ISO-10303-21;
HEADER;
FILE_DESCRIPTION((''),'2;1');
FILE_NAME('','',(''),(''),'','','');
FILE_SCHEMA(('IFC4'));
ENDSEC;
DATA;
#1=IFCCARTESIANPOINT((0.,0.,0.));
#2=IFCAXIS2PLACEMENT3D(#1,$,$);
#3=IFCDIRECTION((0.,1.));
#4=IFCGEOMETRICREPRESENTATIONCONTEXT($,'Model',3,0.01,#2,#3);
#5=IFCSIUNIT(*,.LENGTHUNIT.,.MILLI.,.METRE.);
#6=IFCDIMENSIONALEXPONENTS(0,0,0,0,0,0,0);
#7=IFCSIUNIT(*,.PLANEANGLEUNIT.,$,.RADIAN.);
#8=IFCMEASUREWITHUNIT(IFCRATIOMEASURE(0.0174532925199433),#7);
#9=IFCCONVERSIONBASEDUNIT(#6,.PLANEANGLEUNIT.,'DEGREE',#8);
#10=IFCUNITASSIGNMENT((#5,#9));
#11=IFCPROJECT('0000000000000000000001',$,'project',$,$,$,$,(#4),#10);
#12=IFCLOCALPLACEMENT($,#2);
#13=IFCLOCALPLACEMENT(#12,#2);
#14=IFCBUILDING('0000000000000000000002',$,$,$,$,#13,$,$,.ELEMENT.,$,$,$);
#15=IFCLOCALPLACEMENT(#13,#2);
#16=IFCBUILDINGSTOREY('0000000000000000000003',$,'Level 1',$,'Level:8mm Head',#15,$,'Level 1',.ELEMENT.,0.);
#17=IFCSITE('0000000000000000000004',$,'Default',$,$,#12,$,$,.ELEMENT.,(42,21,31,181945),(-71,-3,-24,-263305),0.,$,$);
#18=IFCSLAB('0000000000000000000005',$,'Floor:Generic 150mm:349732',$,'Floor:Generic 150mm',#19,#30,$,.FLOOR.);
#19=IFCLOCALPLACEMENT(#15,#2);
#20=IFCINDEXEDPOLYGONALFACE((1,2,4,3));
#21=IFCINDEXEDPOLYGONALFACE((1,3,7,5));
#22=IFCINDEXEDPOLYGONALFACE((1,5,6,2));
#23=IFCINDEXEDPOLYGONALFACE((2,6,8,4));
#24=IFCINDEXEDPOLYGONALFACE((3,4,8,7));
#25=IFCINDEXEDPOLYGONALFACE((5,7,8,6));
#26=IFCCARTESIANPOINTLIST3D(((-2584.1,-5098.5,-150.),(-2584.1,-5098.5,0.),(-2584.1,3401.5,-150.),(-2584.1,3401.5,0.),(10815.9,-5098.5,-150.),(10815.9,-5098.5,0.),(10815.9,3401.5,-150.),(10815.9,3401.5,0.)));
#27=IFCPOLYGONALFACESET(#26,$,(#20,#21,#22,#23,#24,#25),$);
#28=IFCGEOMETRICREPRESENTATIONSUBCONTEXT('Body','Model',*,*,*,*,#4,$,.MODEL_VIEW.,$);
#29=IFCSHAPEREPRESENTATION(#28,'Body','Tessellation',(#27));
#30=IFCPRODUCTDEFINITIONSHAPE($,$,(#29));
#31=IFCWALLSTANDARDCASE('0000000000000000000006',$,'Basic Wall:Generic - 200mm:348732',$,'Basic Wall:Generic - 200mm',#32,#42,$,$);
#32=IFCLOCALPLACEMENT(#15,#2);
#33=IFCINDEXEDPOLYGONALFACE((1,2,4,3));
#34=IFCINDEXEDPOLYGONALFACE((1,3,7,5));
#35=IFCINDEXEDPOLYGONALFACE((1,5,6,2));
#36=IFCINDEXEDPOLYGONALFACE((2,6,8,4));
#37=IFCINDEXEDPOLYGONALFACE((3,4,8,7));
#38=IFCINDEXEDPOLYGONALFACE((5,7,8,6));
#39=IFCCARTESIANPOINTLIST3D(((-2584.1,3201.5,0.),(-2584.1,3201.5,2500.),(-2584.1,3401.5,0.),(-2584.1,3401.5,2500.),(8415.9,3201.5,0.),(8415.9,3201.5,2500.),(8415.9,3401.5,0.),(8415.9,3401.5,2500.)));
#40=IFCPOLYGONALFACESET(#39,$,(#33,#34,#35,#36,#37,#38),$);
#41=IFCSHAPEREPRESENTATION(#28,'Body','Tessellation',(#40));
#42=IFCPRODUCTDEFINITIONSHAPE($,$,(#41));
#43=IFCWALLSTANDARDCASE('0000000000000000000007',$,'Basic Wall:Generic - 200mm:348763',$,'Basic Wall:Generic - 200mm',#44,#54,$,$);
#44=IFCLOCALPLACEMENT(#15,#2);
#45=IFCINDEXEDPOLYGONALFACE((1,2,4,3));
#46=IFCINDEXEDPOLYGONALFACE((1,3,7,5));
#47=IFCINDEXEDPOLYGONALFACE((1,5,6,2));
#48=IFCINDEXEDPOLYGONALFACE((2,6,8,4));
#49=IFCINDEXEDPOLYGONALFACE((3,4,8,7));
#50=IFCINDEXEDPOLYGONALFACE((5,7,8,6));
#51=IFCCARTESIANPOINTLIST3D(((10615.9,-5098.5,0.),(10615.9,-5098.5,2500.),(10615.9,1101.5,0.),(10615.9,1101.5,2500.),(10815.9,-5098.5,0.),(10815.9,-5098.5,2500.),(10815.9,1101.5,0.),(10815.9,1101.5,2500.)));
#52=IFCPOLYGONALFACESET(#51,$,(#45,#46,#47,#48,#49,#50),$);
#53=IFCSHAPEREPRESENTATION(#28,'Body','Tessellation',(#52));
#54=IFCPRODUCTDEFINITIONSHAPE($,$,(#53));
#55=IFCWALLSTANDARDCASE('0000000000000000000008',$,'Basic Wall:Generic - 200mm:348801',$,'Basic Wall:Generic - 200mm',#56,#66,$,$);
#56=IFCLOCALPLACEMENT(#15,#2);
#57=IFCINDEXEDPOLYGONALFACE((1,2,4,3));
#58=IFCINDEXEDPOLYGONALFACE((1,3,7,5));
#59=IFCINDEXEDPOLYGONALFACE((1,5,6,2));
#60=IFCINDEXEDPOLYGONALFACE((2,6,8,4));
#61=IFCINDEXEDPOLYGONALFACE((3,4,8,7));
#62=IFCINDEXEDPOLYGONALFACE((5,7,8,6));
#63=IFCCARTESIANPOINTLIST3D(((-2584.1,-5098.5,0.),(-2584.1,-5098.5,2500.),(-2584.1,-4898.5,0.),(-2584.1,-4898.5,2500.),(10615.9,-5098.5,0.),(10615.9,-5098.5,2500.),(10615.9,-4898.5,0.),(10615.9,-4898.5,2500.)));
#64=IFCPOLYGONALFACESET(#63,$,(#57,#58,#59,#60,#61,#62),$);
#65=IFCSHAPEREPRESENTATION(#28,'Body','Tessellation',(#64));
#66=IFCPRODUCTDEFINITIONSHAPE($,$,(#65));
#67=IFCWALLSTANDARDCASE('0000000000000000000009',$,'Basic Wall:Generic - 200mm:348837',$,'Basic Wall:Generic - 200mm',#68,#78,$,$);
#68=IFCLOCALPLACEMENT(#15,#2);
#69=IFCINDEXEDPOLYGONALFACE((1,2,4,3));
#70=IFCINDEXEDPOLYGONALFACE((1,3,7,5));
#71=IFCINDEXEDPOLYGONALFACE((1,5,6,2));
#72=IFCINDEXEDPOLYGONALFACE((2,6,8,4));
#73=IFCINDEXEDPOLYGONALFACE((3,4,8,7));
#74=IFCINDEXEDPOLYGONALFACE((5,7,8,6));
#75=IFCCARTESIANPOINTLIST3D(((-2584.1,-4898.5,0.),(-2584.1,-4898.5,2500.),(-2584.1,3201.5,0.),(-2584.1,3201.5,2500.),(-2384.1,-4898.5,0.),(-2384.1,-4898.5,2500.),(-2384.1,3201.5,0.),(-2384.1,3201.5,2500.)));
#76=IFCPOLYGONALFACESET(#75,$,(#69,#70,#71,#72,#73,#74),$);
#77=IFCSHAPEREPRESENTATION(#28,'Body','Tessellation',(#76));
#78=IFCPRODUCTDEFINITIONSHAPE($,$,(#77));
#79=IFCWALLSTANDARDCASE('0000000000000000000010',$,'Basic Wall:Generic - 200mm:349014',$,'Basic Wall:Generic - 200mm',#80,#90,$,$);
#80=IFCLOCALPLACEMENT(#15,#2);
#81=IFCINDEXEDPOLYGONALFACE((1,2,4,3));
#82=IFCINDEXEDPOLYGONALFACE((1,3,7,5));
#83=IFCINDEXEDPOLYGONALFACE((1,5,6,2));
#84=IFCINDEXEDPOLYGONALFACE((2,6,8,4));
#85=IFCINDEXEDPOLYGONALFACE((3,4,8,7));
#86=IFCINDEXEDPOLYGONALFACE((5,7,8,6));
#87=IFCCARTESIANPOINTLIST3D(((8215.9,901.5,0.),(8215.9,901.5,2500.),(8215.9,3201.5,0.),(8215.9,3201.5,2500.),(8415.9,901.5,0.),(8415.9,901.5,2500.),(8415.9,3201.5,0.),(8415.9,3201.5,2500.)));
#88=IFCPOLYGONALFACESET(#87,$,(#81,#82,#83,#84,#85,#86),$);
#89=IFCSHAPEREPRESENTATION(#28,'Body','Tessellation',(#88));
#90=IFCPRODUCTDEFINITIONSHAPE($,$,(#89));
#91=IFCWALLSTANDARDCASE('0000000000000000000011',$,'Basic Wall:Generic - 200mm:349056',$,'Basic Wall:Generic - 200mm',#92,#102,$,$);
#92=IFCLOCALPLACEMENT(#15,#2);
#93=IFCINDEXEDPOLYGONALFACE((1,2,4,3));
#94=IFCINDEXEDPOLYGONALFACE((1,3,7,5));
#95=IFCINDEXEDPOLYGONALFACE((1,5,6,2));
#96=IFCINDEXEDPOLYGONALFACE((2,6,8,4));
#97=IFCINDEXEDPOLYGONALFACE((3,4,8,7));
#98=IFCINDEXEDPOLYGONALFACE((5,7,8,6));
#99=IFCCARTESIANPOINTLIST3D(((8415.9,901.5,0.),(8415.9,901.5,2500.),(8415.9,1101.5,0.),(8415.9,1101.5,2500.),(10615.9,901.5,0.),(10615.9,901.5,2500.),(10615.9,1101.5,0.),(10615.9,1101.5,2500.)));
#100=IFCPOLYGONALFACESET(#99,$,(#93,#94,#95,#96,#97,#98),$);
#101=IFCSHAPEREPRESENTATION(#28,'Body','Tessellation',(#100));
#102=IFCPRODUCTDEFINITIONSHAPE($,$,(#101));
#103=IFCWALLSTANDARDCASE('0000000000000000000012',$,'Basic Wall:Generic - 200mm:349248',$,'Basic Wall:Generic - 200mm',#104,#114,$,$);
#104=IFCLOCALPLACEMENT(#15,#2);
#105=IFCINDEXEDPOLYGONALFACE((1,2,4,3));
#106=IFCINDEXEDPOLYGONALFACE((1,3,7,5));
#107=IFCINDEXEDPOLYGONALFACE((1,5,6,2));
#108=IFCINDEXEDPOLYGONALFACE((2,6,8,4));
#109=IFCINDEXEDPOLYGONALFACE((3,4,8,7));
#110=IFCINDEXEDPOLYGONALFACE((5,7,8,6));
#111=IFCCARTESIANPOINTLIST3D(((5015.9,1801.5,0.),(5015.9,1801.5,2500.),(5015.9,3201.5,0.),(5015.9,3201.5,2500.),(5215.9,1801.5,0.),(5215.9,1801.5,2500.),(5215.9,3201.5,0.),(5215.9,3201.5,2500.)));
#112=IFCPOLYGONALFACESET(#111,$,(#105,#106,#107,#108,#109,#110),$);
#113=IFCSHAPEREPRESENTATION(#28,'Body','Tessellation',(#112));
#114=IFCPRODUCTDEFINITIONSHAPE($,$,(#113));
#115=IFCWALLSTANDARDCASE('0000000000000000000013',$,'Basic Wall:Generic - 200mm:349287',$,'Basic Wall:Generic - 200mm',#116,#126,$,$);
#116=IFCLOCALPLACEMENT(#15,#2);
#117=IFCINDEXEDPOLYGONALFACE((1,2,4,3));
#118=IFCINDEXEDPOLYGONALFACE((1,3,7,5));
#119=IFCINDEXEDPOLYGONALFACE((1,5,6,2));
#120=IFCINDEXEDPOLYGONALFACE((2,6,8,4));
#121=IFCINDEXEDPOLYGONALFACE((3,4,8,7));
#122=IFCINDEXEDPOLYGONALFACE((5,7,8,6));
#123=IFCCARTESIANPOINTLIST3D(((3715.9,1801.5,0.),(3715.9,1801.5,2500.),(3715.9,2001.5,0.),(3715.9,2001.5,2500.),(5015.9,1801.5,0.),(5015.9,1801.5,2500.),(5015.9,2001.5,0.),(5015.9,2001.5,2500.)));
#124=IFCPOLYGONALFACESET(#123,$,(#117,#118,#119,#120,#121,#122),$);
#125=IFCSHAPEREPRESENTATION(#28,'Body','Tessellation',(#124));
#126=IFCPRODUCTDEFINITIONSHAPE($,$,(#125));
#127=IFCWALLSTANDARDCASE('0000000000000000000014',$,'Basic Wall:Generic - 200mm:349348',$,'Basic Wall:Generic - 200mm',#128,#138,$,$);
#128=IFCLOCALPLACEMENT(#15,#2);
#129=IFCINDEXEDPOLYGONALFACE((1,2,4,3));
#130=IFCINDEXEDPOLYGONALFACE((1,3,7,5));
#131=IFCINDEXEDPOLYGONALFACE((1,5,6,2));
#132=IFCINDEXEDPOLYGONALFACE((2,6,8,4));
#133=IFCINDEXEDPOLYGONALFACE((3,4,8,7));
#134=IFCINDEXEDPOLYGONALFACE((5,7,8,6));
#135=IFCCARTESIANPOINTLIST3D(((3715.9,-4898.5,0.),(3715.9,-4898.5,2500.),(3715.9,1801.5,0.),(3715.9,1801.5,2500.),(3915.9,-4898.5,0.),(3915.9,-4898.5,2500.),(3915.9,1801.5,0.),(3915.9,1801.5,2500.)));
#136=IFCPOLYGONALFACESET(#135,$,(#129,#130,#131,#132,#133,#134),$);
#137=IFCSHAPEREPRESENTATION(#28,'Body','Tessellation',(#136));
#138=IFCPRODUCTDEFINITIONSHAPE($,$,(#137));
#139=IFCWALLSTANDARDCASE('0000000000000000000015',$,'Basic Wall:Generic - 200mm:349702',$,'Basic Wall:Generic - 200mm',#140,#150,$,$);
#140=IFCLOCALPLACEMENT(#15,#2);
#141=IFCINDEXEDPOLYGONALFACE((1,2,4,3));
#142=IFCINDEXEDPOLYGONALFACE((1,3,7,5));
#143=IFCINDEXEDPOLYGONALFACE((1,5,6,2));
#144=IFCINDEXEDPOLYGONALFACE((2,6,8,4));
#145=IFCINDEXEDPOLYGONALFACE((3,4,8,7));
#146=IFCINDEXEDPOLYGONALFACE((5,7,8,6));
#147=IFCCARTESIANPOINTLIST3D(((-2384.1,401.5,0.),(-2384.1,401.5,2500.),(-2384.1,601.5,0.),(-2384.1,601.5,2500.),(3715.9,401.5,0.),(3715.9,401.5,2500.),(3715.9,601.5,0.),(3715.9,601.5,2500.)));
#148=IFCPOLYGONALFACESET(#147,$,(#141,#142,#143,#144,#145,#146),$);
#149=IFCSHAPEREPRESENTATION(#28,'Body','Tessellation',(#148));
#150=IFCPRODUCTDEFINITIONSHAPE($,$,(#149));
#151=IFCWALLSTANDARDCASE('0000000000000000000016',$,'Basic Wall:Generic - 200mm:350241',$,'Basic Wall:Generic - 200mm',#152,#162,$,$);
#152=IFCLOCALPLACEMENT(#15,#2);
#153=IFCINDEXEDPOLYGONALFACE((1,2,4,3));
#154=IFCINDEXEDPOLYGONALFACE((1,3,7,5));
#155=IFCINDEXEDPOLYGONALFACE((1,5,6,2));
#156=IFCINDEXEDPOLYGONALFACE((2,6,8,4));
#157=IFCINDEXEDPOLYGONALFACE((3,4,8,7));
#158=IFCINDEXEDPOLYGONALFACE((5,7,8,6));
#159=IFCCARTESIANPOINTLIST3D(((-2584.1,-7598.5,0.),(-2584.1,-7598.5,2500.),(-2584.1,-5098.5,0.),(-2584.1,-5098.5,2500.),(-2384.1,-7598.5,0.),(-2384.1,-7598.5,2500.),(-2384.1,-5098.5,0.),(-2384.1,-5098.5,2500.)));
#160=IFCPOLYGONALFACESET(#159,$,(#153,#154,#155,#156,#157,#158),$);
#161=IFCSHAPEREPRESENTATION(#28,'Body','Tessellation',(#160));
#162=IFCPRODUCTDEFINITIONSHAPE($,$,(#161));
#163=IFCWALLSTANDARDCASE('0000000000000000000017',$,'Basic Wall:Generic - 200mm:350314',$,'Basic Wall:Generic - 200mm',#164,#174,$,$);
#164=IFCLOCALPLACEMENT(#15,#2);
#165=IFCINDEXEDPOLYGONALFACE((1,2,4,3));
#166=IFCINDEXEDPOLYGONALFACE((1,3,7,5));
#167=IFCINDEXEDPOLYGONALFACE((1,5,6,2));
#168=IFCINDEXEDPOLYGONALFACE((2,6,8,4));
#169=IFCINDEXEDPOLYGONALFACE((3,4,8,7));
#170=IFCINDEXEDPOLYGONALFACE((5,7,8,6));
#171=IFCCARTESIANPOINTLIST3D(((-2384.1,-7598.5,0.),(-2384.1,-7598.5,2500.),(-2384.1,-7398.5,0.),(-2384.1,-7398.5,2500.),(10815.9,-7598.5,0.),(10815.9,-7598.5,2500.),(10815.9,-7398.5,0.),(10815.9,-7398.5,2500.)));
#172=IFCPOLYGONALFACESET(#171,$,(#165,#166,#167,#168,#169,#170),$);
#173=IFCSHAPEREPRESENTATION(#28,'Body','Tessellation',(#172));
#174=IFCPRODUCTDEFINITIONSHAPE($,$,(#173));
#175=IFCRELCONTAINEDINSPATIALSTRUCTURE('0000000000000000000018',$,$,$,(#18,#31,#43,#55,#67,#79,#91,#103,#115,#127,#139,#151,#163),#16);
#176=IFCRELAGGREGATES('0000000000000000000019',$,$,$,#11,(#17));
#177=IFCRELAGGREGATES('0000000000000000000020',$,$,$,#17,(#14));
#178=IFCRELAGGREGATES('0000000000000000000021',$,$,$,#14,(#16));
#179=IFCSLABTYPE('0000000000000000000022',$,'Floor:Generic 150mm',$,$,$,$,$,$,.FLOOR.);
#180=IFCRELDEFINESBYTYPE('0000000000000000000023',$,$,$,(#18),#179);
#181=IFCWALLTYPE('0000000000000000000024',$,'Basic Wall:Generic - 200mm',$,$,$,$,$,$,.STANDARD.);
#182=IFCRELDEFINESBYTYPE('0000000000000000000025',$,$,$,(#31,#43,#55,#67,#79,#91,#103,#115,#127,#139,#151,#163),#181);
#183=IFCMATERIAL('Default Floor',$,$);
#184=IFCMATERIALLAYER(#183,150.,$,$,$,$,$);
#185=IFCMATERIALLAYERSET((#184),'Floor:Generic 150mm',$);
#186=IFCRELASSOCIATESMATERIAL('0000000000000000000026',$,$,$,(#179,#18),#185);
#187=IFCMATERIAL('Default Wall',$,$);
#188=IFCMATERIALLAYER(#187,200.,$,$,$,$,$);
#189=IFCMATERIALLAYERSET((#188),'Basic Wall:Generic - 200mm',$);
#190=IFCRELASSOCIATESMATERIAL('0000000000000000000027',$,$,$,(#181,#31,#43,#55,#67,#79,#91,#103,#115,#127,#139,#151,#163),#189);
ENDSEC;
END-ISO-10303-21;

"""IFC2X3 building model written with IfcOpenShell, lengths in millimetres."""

from ifc_helpers import new_model, entity, si_unit, converted_unit, direction, frame, frame_2d, origin, place, context, subcontext, project, spatial, rectangle, extrude, material, layer, layer_set, layer_usage, type_object, element, save


model = new_model("IFC2X3")

# Units and contexts
model_context = context("Model", 3, precision=0.01, world=origin(), true_north=direction((0.0, 1.0)))
body_context = subcontext(model_context, "Body", "Model", "MODEL_VIEW")
ifc_project = project(units=[si_unit("LENGTHUNIT", "METRE", prefix="MILLI"), converted_unit("PLANEANGLEUNIT", "DEGREE", entity("IfcRatioMeasure", 0.0174532925199433), si_unit("PLANEANGLEUNIT", "RADIAN"), dimensions=[0, 0, 0, 0, 0, 0, 0])], contexts=[model_context])

# Site, building, storey
site_placement = place(None, origin())
site = spatial("IfcSite", under=ifc_project, at=site_placement, Name="Default", CompositionType="ELEMENT", RefLatitude=(42, 21, 31, 181945), RefLongitude=(-71, -3, -24, -263305), RefElevation=0.0)
building_placement = place(site_placement, origin())
building = spatial("IfcBuilding", under=site, at=building_placement, CompositionType="ELEMENT")
storey_placement = place(building_placement, origin())
storey = spatial("IfcBuildingStorey", under=building, at=storey_placement, Name="Level 1", ObjectType="Level:8mm Head", LongName="Level 1", CompositionType="ELEMENT", Elevation=0.0)

# Slab
ifc_material_1 = material(Name="Default Floor")
ifc_layer_1 = layer(ifc_material_1, 150.0)
ifc_layer_set_1 = layer_set([ifc_layer_1], Name="Floor:Generic 150mm")
ifc_layer_usage_1 = layer_usage(ifc_layer_set_1, "AXIS3", "POSITIVE", 0.0)
slab_type = type_object("IfcSlabType", Name="Floor:Generic 150mm", PredefinedType="FLOOR", material=ifc_layer_set_1)
slab_placement = place(storey_placement, origin())
element("IfcSlab", 1, at=slab_placement, inside=storey, type_object=slab_type, material=ifc_layer_usage_1, Name="Floor:Generic 150mm:349732", ObjectType="Floor:Generic 150mm", PredefinedType="FLOOR", context=body_context, shape_type="SweptSolid", body=[
    extrude(rectangle(XDim=8500.0, YDim=13400.0, at=frame_2d((0.0, 0.0), x_axis=(1.0, 0.0))), frame((4115.9, -848.5, 0.0), z_axis=(0.0, 0.0, -1.0), x_axis=(0.0, 1.0, 0.0)), (0.0, 0.0, 1.0), 150.0),
])

# Walls
ifc_material_2 = material(Name="Default Wall")
ifc_layer_2 = layer(ifc_material_2, 200.0)
ifc_layer_set_2 = layer_set([ifc_layer_2], Name="Basic Wall:Generic - 200mm")
ifc_layer_usage_2 = layer_usage(ifc_layer_set_2, "AXIS2", "NEGATIVE", 100.0)
wall_type = type_object("IfcWallType", Name="Basic Wall:Generic - 200mm", PredefinedType="STANDARD", material=ifc_layer_set_2)
wall_1_placement = place(storey_placement, frame((-2584.1, 3301.5, 0.0)))
element("IfcWallStandardCase", 2, at=wall_1_placement, inside=storey, type_object=wall_type, material=ifc_layer_usage_2, Name="Basic Wall:Generic - 200mm:348732", ObjectType="Basic Wall:Generic - 200mm", context=body_context, shape_type="SweptSolid", body=[
    extrude(rectangle(XDim=11000.0, YDim=200.0, at=frame_2d((5500.0, 0.0), x_axis=(-1.0, 0.0))), origin(), (0.0, 0.0, 1.0), 2500.0),
])
ifc_layer_usage_3 = layer_usage(ifc_layer_set_2, "AXIS2", "NEGATIVE", 100.0)
wall_2_placement = place(storey_placement, frame((10715.9, 1101.5, 0.0), z_axis=(0.0, 0.0, 1.0), x_axis=(0.0, -1.0, 0.0)))
element("IfcWallStandardCase", 3, at=wall_2_placement, inside=storey, type_object=wall_type, material=ifc_layer_usage_3, Name="Basic Wall:Generic - 200mm:348763", ObjectType="Basic Wall:Generic - 200mm", context=body_context, shape_type="SweptSolid", body=[
    extrude(rectangle(XDim=6200.0, YDim=200.0, at=frame_2d((3100.0, 0.0), x_axis=(-1.0, 0.0))), origin(), (0.0, 0.0, 1.0), 2500.0),
])
ifc_layer_usage_4 = layer_usage(ifc_layer_set_2, "AXIS2", "NEGATIVE", 100.0)
wall_3_placement = place(storey_placement, frame((10615.9, -4998.5, 0.0), z_axis=(0.0, 0.0, 1.0), x_axis=(-1.0, 0.0, 0.0)))
element("IfcWallStandardCase", 4, at=wall_3_placement, inside=storey, type_object=wall_type, material=ifc_layer_usage_4, Name="Basic Wall:Generic - 200mm:348801", ObjectType="Basic Wall:Generic - 200mm", context=body_context, shape_type="SweptSolid", body=[
    extrude(rectangle(XDim=13200.0, YDim=200.0, at=frame_2d((6600.0, 0.0), x_axis=(-1.0, 0.0))), origin(), (0.0, 0.0, 1.0), 2500.0),
])
ifc_layer_usage_5 = layer_usage(ifc_layer_set_2, "AXIS2", "NEGATIVE", 100.0)
wall_4_placement = place(storey_placement, frame((-2484.1, -4898.5, 0.0), z_axis=(0.0, 0.0, 1.0), x_axis=(0.0, 1.0, 0.0)))
element("IfcWallStandardCase", 5, at=wall_4_placement, inside=storey, type_object=wall_type, material=ifc_layer_usage_5, Name="Basic Wall:Generic - 200mm:348837", ObjectType="Basic Wall:Generic - 200mm", context=body_context, shape_type="SweptSolid", body=[
    extrude(rectangle(XDim=8100.0, YDim=200.0, at=frame_2d((4050.0, 0.0), x_axis=(-1.0, 0.0))), origin(), (0.0, 0.0, 1.0), 2500.0),
])
ifc_layer_usage_6 = layer_usage(ifc_layer_set_2, "AXIS2", "NEGATIVE", 100.0)
wall_5_placement = place(storey_placement, frame((8315.9, 3201.5, 0.0), z_axis=(0.0, 0.0, 1.0), x_axis=(0.0, -1.0, 0.0)))
element("IfcWallStandardCase", 6, at=wall_5_placement, inside=storey, type_object=wall_type, material=ifc_layer_usage_6, Name="Basic Wall:Generic - 200mm:349014", ObjectType="Basic Wall:Generic - 200mm", context=body_context, shape_type="SweptSolid", body=[
    extrude(rectangle(XDim=2300.0, YDim=200.0, at=frame_2d((1150.0, 0.0), x_axis=(-1.0, 0.0))), origin(), (0.0, 0.0, 1.0), 2500.0),
])
ifc_layer_usage_7 = layer_usage(ifc_layer_set_2, "AXIS2", "NEGATIVE", 100.0)
wall_6_placement = place(storey_placement, frame((8415.9, 1001.5, 0.0)))
element("IfcWallStandardCase", 7, at=wall_6_placement, inside=storey, type_object=wall_type, material=ifc_layer_usage_7, Name="Basic Wall:Generic - 200mm:349056", ObjectType="Basic Wall:Generic - 200mm", context=body_context, shape_type="SweptSolid", body=[
    extrude(rectangle(XDim=2200.0, YDim=200.0, at=frame_2d((1100.0, 0.0), x_axis=(-1.0, 0.0))), origin(), (0.0, 0.0, 1.0), 2500.0),
])
ifc_layer_usage_8 = layer_usage(ifc_layer_set_2, "AXIS2", "NEGATIVE", 100.0)
wall_7_placement = place(storey_placement, frame((5115.9, 3201.5, 0.0), z_axis=(0.0, 0.0, 1.0), x_axis=(0.0, -1.0, 0.0)))
element("IfcWallStandardCase", 8, at=wall_7_placement, inside=storey, type_object=wall_type, material=ifc_layer_usage_8, Name="Basic Wall:Generic - 200mm:349248", ObjectType="Basic Wall:Generic - 200mm", context=body_context, shape_type="SweptSolid", body=[
    extrude(rectangle(XDim=1400.0, YDim=200.0, at=frame_2d((700.0, 0.0), x_axis=(-1.0, 0.0))), origin(), (0.0, 0.0, 1.0), 2500.0),
])
ifc_layer_usage_9 = layer_usage(ifc_layer_set_2, "AXIS2", "NEGATIVE", 100.0)
wall_8_placement = place(storey_placement, frame((5015.9, 1901.5, 0.0), z_axis=(0.0, 0.0, 1.0), x_axis=(-1.0, 0.0, 0.0)))
element("IfcWallStandardCase", 9, at=wall_8_placement, inside=storey, type_object=wall_type, material=ifc_layer_usage_9, Name="Basic Wall:Generic - 200mm:349287", ObjectType="Basic Wall:Generic - 200mm", context=body_context, shape_type="SweptSolid", body=[
    extrude(rectangle(XDim=1300.0, YDim=200.0, at=frame_2d((650.0, 0.0), x_axis=(-1.0, 0.0))), origin(), (0.0, 0.0, 1.0), 2500.0),
])
ifc_layer_usage_10 = layer_usage(ifc_layer_set_2, "AXIS2", "NEGATIVE", 100.0)
wall_9_placement = place(storey_placement, frame((3815.9, 1801.5, 0.0), z_axis=(0.0, 0.0, 1.0), x_axis=(0.0, -1.0, 0.0)))
element("IfcWallStandardCase", 10, at=wall_9_placement, inside=storey, type_object=wall_type, material=ifc_layer_usage_10, Name="Basic Wall:Generic - 200mm:349348", ObjectType="Basic Wall:Generic - 200mm", context=body_context, shape_type="SweptSolid", body=[
    extrude(rectangle(XDim=6700.0, YDim=200.0, at=frame_2d((3350.0, 0.0), x_axis=(-1.0, 0.0))), origin(), (0.0, 0.0, 1.0), 2500.0),
])
ifc_layer_usage_11 = layer_usage(ifc_layer_set_2, "AXIS2", "NEGATIVE", 100.0)
wall_10_placement = place(storey_placement, frame((3715.9, 501.5, 0.0), z_axis=(0.0, 0.0, 1.0), x_axis=(-1.0, 0.0, 0.0)))
element("IfcWallStandardCase", 11, at=wall_10_placement, inside=storey, type_object=wall_type, material=ifc_layer_usage_11, Name="Basic Wall:Generic - 200mm:349702", ObjectType="Basic Wall:Generic - 200mm", context=body_context, shape_type="SweptSolid", body=[
    extrude(rectangle(XDim=6100.0, YDim=200.0, at=frame_2d((3050.0, 0.0), x_axis=(-1.0, 0.0))), origin(), (0.0, 0.0, 1.0), 2500.0),
])
ifc_layer_usage_12 = layer_usage(ifc_layer_set_2, "AXIS2", "NEGATIVE", 100.0)
wall_11_placement = place(storey_placement, frame((-2484.1, -5098.5, 0.0), z_axis=(0.0, 0.0, 1.0), x_axis=(0.0, -1.0, 0.0)))
element("IfcWallStandardCase", 12, at=wall_11_placement, inside=storey, type_object=wall_type, material=ifc_layer_usage_12, Name="Basic Wall:Generic - 200mm:350241", ObjectType="Basic Wall:Generic - 200mm", context=body_context, shape_type="SweptSolid", body=[
    extrude(rectangle(XDim=2500.0, YDim=200.0, at=frame_2d((1250.0, 0.0), x_axis=(-1.0, 0.0))), origin(), (0.0, 0.0, 1.0), 2500.0),
])
ifc_layer_usage_13 = layer_usage(ifc_layer_set_2, "AXIS2", "NEGATIVE", 100.0)
wall_12_placement = place(storey_placement, frame((-2384.1, -7498.5, 0.0)))
element("IfcWallStandardCase", 13, at=wall_12_placement, inside=storey, type_object=wall_type, material=ifc_layer_usage_13, Name="Basic Wall:Generic - 200mm:350314", ObjectType="Basic Wall:Generic - 200mm", context=body_context, shape_type="SweptSolid", body=[
    extrude(rectangle(XDim=13200.0, YDim=200.0, at=frame_2d((6600.0, 0.0), x_axis=(-1.0, 0.0))), origin(), (0.0, 0.0, 1.0), 2500.0),
])

save(model, "model.ifc")
